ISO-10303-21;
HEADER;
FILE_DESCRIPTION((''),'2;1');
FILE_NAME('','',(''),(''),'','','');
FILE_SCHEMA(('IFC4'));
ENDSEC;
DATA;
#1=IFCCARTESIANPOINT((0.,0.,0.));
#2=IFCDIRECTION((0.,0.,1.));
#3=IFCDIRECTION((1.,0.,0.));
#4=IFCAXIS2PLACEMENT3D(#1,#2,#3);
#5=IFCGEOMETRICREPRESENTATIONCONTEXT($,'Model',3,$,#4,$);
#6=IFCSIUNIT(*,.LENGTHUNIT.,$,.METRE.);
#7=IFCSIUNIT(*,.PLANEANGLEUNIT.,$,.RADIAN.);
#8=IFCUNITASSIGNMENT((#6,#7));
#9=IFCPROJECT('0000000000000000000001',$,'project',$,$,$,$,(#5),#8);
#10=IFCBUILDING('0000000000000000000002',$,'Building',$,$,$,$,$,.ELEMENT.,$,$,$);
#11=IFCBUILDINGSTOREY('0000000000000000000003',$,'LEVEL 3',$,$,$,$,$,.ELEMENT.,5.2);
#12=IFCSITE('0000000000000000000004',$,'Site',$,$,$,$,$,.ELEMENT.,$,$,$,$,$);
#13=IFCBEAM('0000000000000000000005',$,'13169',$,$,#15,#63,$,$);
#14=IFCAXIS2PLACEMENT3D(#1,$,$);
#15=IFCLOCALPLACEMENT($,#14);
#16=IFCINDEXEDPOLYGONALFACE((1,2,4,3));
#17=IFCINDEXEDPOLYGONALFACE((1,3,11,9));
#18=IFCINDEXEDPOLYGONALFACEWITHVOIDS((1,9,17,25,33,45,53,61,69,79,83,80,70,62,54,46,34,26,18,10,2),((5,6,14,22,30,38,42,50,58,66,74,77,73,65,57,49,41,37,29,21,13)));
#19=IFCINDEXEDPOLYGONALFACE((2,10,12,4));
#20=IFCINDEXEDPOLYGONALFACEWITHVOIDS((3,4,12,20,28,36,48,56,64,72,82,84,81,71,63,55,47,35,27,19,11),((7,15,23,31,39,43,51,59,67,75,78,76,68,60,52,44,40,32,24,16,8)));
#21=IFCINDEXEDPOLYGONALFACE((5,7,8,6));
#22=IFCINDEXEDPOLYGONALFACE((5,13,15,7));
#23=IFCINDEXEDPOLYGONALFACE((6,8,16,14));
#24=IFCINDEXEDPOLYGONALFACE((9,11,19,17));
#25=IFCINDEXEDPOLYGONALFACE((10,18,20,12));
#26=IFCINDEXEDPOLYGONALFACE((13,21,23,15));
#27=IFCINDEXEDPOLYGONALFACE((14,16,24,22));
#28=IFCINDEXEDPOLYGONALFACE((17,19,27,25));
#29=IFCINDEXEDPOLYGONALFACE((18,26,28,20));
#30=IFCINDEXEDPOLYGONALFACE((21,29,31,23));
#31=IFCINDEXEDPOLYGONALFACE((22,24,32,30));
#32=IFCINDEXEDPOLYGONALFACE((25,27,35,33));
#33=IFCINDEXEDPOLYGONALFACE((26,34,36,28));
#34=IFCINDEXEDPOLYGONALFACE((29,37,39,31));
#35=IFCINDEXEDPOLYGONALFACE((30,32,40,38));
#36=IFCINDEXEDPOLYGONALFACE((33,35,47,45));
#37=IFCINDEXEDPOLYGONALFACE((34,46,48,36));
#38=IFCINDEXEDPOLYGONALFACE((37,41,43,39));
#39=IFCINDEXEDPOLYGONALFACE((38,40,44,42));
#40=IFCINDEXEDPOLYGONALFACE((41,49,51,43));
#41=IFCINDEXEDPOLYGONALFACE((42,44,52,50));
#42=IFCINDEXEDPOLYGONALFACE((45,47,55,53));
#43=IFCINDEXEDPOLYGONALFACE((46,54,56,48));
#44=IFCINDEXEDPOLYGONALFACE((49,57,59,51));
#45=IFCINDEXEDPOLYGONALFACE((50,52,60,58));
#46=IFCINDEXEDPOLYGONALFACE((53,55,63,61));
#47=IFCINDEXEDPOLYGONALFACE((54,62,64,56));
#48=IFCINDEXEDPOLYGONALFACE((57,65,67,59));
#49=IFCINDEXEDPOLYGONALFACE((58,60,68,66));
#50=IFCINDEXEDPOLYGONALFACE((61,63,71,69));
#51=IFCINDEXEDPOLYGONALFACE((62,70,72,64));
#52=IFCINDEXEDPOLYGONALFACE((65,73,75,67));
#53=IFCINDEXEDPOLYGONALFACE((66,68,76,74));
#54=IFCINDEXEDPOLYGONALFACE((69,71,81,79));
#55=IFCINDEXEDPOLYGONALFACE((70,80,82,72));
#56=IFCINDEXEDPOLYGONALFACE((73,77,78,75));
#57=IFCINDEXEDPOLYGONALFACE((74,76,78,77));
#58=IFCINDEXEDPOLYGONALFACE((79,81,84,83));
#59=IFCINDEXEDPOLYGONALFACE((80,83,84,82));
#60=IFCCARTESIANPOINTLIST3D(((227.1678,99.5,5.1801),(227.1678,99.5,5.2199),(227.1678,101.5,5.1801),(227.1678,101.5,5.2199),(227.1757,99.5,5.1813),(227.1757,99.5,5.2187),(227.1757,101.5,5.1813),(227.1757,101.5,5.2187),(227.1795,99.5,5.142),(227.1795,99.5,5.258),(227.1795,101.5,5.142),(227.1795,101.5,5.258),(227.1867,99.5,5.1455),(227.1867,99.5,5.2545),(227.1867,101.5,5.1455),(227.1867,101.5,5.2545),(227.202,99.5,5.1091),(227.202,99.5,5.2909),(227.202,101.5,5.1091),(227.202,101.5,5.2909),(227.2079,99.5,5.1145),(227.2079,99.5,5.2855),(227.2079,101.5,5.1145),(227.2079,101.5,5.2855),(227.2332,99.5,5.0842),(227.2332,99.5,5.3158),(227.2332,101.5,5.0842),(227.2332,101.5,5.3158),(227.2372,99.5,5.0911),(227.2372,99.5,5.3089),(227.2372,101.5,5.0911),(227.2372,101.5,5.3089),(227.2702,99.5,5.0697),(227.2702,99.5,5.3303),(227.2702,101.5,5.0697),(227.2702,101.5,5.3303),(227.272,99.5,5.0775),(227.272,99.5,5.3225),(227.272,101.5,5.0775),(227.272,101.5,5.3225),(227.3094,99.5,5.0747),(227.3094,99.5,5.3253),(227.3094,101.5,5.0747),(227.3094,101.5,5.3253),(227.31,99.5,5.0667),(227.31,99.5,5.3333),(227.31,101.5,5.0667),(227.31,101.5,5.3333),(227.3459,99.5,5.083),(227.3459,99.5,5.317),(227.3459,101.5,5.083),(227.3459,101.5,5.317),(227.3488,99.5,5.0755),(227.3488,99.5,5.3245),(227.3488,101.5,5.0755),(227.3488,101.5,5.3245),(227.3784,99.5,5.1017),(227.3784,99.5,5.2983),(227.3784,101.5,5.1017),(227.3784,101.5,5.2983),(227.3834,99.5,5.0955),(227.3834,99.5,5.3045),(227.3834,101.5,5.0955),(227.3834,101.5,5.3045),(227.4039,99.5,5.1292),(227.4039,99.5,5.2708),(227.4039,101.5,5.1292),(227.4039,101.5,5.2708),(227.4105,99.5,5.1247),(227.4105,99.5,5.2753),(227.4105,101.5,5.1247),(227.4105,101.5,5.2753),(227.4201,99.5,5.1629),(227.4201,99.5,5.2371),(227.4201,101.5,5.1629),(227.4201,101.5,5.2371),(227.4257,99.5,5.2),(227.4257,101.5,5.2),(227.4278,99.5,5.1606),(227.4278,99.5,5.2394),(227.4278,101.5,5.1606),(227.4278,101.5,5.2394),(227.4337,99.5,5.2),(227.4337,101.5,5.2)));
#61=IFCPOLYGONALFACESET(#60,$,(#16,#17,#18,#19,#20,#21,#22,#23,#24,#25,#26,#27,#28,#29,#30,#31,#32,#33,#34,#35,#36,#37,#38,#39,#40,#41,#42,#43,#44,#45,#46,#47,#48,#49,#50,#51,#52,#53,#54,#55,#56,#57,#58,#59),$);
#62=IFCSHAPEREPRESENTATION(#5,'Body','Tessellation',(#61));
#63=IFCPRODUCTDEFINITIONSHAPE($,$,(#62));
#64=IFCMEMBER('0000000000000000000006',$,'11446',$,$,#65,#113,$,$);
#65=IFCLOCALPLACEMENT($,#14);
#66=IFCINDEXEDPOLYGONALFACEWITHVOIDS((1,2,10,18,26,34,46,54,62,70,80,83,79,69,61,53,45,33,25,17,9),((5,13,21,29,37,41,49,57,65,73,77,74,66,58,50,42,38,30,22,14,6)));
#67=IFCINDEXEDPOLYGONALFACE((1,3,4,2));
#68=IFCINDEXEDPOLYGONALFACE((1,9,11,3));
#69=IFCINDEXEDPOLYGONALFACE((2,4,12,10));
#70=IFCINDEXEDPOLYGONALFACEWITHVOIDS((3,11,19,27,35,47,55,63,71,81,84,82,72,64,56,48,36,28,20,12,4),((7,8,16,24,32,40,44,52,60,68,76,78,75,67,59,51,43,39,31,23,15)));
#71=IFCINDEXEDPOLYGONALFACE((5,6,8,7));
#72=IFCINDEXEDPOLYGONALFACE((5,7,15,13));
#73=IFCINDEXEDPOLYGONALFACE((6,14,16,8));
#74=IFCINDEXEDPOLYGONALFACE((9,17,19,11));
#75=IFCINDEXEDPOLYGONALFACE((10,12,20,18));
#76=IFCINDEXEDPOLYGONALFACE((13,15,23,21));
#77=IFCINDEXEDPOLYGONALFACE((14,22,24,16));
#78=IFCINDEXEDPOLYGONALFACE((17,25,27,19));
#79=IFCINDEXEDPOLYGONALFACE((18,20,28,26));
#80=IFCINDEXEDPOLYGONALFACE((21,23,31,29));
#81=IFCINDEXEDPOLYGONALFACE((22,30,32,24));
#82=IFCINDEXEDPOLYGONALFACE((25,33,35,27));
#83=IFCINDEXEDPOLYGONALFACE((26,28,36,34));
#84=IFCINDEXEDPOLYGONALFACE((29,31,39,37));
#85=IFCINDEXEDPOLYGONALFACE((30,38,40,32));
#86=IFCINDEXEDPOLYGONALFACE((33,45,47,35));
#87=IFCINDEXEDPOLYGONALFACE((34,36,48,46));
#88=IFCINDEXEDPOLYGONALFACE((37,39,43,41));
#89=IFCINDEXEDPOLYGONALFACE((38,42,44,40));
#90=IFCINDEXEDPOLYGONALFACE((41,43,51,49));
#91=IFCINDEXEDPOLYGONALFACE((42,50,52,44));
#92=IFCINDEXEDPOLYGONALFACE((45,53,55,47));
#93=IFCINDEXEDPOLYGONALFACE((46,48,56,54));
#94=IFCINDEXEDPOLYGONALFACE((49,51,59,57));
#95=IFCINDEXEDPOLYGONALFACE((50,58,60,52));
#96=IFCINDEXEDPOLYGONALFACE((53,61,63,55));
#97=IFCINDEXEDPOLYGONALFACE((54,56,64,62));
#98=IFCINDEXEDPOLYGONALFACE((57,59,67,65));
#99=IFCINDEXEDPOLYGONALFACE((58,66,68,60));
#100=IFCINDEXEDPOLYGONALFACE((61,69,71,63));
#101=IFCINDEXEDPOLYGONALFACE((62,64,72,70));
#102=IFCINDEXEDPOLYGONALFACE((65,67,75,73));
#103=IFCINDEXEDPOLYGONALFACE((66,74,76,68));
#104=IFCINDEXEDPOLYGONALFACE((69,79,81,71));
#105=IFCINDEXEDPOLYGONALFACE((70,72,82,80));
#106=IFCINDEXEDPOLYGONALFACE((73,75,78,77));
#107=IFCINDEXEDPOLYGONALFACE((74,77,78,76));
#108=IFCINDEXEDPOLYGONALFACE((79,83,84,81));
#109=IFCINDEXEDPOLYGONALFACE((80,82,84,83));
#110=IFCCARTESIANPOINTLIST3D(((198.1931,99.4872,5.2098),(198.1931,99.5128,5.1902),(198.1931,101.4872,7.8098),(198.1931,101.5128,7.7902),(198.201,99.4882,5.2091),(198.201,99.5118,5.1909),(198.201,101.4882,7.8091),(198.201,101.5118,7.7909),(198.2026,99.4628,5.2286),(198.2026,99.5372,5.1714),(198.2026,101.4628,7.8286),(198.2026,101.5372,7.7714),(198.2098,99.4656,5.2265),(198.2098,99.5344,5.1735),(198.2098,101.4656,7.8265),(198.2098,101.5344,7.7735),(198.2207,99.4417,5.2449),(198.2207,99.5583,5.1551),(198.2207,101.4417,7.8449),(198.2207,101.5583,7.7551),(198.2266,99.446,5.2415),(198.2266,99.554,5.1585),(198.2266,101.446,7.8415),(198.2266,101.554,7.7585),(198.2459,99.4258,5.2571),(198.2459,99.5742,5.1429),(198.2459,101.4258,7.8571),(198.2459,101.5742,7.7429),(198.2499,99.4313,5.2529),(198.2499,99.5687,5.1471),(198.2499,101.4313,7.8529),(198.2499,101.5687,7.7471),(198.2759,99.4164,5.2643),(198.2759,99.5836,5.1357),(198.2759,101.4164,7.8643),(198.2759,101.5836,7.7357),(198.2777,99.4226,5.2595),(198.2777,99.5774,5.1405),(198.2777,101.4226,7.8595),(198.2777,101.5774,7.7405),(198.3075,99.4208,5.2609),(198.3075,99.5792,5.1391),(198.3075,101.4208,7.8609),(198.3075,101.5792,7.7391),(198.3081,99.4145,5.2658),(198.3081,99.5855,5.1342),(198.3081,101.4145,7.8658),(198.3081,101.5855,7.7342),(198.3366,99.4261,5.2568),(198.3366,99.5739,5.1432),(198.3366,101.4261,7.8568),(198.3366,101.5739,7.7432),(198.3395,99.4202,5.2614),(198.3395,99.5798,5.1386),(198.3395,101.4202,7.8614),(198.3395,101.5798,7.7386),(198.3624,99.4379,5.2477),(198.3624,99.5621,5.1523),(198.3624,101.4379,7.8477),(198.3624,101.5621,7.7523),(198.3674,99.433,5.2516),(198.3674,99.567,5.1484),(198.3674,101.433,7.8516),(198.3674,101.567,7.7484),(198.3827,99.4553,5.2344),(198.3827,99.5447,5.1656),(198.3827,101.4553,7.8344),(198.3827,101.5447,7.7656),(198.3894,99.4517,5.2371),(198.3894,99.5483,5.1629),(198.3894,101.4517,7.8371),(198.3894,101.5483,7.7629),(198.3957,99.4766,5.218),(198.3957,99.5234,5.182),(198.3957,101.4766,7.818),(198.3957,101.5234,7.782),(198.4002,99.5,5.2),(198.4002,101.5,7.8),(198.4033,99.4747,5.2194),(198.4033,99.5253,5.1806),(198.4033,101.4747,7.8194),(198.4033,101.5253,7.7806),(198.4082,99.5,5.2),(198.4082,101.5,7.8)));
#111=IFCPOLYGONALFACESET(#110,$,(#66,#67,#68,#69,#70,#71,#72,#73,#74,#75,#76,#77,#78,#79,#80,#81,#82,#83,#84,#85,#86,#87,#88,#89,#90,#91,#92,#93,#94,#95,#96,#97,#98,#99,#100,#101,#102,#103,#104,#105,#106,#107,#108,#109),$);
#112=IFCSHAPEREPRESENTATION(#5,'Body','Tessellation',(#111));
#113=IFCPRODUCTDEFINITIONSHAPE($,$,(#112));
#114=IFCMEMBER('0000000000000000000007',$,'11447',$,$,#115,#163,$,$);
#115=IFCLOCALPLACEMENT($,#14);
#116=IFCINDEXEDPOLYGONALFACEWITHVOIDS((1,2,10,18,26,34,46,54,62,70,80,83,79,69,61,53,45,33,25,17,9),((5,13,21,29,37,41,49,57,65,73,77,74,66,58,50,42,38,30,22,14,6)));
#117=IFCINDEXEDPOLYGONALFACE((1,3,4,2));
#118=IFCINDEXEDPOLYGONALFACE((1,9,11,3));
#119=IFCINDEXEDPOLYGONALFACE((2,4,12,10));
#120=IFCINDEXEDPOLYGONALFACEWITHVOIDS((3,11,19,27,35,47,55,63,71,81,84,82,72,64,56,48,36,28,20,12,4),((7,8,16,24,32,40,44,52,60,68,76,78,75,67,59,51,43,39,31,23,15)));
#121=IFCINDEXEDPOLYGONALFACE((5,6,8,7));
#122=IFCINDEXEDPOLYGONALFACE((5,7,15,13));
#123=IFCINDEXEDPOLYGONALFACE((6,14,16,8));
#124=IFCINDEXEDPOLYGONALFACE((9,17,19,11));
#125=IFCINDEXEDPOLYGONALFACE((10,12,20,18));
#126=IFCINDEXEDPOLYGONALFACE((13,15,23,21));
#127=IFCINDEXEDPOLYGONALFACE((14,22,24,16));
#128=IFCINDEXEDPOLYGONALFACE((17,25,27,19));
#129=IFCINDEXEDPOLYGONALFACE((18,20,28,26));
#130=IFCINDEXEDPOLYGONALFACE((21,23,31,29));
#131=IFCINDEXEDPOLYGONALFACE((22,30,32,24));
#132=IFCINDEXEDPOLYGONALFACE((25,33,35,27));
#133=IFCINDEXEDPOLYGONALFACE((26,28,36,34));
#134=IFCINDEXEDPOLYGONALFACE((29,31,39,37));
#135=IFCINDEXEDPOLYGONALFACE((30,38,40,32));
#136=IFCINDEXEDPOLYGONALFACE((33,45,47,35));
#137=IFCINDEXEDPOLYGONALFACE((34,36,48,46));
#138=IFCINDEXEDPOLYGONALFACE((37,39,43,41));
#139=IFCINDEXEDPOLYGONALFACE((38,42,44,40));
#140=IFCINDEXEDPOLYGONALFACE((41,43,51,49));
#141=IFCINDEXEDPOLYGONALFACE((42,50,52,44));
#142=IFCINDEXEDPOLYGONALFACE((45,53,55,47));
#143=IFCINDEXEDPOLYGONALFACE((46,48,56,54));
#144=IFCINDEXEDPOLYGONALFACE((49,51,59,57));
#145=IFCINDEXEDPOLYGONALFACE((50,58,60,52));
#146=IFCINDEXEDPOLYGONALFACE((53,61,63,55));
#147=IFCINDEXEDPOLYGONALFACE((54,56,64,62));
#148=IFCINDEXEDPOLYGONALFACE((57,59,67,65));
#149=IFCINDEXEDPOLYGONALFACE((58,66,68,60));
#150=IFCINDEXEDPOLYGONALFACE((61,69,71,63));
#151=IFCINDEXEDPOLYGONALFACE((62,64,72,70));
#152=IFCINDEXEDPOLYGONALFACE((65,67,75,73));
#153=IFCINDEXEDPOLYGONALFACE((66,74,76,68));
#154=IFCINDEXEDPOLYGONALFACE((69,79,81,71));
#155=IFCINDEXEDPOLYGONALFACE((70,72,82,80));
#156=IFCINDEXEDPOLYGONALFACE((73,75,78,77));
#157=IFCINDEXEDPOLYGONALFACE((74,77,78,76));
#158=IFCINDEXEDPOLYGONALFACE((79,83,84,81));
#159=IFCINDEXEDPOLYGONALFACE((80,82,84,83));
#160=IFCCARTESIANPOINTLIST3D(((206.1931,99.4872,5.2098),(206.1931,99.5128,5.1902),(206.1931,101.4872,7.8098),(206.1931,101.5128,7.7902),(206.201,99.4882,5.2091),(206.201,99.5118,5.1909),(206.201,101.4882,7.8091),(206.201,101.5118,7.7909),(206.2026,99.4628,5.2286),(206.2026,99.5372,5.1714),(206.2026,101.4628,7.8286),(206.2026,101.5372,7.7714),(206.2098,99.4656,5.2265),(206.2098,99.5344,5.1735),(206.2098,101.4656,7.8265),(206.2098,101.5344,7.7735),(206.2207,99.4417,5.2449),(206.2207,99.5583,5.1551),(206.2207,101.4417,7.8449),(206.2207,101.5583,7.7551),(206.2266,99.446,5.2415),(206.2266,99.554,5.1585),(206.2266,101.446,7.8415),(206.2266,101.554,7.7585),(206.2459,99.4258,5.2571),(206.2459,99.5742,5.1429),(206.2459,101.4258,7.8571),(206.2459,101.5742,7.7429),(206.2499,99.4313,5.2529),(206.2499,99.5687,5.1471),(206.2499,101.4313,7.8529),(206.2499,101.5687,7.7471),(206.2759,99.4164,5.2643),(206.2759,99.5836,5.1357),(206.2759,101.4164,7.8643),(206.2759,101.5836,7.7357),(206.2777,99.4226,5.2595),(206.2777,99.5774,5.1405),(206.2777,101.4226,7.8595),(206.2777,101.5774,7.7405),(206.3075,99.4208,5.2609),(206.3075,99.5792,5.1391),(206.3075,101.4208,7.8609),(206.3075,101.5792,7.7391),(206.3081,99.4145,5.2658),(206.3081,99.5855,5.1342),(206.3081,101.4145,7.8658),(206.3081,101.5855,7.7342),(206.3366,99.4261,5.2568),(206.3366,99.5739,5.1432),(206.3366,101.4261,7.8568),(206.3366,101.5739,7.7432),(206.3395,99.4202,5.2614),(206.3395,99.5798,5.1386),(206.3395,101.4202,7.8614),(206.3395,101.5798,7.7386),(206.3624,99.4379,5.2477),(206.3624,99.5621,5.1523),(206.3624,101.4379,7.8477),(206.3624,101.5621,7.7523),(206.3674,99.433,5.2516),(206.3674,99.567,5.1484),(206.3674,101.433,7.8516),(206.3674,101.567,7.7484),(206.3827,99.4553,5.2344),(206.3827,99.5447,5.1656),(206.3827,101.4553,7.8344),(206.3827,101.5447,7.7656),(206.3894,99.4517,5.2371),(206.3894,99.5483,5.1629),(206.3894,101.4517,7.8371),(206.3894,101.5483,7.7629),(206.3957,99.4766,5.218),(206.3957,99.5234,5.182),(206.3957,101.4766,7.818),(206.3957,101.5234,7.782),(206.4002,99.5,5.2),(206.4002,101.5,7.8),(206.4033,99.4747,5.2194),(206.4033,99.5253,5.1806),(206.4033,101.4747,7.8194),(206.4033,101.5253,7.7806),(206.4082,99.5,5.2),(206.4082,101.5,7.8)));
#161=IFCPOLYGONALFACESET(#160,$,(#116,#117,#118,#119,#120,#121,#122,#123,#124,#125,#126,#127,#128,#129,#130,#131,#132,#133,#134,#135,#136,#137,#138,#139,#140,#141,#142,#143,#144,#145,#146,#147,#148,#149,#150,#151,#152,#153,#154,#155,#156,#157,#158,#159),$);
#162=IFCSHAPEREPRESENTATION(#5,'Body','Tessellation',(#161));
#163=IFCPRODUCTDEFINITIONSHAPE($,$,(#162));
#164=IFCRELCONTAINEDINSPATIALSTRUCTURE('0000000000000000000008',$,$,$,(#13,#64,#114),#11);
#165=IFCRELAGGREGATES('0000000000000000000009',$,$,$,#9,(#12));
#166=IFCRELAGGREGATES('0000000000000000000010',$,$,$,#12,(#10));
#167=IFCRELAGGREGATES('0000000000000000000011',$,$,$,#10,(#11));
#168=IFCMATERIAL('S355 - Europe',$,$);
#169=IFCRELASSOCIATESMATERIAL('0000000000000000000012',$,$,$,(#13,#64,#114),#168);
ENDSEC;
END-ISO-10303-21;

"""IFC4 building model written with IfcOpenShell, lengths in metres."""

from ifc_helpers import new_model, si_unit, frame, origin_with_axes, origin_2d_with_axis, place, context, project, spatial, hollow_circle, extrude, material, material_profile, profile_set, profile_usage, element, save


model = new_model("IFC4")

# Units and contexts
model_context = context("Model", 3, world=origin_with_axes())
ifc_project = project(units=[si_unit("LENGTHUNIT", "METRE"), si_unit("PLANEANGLEUNIT", "RADIAN")], contexts=[model_context])

# Site, building, storey
site = spatial("IfcSite", under=ifc_project, Name="Site", CompositionType="ELEMENT")
building = spatial("IfcBuilding", under=site, Name="Building", CompositionType="ELEMENT")
storey = spatial("IfcBuildingStorey", under=building, Name="LEVEL 3", CompositionType="ELEMENT", Elevation=5.2)

# Shared definitions
ifc_material = material(Name="S355 - Europe")

# Beam
ifc_material_profile_1 = material_profile(ifc_material, hollow_circle(Radius=0.1337, WallThickness=0.008, at=origin_2d_with_axis()))
ifc_profile_set_1 = profile_set([ifc_material_profile_1])
ifc_profile_usage_1 = profile_usage(ifc_profile_set_1, cardinal=10)
beam_1_placement = place(None, frame((227.3, 101.5, 5.2), z_axis=(0.0, -1.0, 0.0), x_axis=(1.0, 0.0, 0.0)))
element("IfcBeam", 1, at=beam_1_placement, inside=storey, material=ifc_profile_usage_1, Name="13169", context=model_context, shape_type="SweptSolid", body=[
    extrude(hollow_circle(Radius=0.1337, WallThickness=0.008, at=origin_2d_with_axis()), origin_with_axes(), (0.0, 0.0, 1.0), 2.0),
])

# Members
ifc_material_profile_2 = material_profile(ifc_material, hollow_circle(Radius=0.1081, WallThickness=0.008, at=origin_2d_with_axis()))
ifc_profile_set_2 = profile_set([ifc_material_profile_2])
ifc_profile_usage_2 = profile_usage(ifc_profile_set_2, cardinal=10)
member_1_placement = place(None, frame((198.3, 101.5, 7.8), z_axis=(0.0, -0.609711, -0.792624), x_axis=(1.0, 0.0, 0.0)))
element("IfcMember", 2, at=member_1_placement, inside=storey, material=ifc_profile_usage_2, Name="11446", context=model_context, shape_type="SweptSolid", body=[
    extrude(hollow_circle(Radius=0.1081, WallThickness=0.008, at=origin_2d_with_axis()), origin_with_axes(), (0.0, 0.0, 1.0), 3.2802),
])
ifc_material_profile_3 = material_profile(ifc_material, hollow_circle(Radius=0.1081, WallThickness=0.008, at=origin_2d_with_axis()))
ifc_profile_set_3 = profile_set([ifc_material_profile_3])
ifc_profile_usage_3 = profile_usage(ifc_profile_set_3, cardinal=10)
member_2_placement = place(None, frame((206.3, 101.5, 7.8), z_axis=(0.0, -0.609711, -0.792624), x_axis=(1.0, 0.0, 0.0)))
element("IfcMember", 3, at=member_2_placement, inside=storey, material=ifc_profile_usage_3, Name="11447", context=model_context, shape_type="SweptSolid", body=[
    extrude(hollow_circle(Radius=0.1081, WallThickness=0.008, at=origin_2d_with_axis()), origin_with_axes(), (0.0, 0.0, 1.0), 3.2802),
])

save(model, "model.ifc")
